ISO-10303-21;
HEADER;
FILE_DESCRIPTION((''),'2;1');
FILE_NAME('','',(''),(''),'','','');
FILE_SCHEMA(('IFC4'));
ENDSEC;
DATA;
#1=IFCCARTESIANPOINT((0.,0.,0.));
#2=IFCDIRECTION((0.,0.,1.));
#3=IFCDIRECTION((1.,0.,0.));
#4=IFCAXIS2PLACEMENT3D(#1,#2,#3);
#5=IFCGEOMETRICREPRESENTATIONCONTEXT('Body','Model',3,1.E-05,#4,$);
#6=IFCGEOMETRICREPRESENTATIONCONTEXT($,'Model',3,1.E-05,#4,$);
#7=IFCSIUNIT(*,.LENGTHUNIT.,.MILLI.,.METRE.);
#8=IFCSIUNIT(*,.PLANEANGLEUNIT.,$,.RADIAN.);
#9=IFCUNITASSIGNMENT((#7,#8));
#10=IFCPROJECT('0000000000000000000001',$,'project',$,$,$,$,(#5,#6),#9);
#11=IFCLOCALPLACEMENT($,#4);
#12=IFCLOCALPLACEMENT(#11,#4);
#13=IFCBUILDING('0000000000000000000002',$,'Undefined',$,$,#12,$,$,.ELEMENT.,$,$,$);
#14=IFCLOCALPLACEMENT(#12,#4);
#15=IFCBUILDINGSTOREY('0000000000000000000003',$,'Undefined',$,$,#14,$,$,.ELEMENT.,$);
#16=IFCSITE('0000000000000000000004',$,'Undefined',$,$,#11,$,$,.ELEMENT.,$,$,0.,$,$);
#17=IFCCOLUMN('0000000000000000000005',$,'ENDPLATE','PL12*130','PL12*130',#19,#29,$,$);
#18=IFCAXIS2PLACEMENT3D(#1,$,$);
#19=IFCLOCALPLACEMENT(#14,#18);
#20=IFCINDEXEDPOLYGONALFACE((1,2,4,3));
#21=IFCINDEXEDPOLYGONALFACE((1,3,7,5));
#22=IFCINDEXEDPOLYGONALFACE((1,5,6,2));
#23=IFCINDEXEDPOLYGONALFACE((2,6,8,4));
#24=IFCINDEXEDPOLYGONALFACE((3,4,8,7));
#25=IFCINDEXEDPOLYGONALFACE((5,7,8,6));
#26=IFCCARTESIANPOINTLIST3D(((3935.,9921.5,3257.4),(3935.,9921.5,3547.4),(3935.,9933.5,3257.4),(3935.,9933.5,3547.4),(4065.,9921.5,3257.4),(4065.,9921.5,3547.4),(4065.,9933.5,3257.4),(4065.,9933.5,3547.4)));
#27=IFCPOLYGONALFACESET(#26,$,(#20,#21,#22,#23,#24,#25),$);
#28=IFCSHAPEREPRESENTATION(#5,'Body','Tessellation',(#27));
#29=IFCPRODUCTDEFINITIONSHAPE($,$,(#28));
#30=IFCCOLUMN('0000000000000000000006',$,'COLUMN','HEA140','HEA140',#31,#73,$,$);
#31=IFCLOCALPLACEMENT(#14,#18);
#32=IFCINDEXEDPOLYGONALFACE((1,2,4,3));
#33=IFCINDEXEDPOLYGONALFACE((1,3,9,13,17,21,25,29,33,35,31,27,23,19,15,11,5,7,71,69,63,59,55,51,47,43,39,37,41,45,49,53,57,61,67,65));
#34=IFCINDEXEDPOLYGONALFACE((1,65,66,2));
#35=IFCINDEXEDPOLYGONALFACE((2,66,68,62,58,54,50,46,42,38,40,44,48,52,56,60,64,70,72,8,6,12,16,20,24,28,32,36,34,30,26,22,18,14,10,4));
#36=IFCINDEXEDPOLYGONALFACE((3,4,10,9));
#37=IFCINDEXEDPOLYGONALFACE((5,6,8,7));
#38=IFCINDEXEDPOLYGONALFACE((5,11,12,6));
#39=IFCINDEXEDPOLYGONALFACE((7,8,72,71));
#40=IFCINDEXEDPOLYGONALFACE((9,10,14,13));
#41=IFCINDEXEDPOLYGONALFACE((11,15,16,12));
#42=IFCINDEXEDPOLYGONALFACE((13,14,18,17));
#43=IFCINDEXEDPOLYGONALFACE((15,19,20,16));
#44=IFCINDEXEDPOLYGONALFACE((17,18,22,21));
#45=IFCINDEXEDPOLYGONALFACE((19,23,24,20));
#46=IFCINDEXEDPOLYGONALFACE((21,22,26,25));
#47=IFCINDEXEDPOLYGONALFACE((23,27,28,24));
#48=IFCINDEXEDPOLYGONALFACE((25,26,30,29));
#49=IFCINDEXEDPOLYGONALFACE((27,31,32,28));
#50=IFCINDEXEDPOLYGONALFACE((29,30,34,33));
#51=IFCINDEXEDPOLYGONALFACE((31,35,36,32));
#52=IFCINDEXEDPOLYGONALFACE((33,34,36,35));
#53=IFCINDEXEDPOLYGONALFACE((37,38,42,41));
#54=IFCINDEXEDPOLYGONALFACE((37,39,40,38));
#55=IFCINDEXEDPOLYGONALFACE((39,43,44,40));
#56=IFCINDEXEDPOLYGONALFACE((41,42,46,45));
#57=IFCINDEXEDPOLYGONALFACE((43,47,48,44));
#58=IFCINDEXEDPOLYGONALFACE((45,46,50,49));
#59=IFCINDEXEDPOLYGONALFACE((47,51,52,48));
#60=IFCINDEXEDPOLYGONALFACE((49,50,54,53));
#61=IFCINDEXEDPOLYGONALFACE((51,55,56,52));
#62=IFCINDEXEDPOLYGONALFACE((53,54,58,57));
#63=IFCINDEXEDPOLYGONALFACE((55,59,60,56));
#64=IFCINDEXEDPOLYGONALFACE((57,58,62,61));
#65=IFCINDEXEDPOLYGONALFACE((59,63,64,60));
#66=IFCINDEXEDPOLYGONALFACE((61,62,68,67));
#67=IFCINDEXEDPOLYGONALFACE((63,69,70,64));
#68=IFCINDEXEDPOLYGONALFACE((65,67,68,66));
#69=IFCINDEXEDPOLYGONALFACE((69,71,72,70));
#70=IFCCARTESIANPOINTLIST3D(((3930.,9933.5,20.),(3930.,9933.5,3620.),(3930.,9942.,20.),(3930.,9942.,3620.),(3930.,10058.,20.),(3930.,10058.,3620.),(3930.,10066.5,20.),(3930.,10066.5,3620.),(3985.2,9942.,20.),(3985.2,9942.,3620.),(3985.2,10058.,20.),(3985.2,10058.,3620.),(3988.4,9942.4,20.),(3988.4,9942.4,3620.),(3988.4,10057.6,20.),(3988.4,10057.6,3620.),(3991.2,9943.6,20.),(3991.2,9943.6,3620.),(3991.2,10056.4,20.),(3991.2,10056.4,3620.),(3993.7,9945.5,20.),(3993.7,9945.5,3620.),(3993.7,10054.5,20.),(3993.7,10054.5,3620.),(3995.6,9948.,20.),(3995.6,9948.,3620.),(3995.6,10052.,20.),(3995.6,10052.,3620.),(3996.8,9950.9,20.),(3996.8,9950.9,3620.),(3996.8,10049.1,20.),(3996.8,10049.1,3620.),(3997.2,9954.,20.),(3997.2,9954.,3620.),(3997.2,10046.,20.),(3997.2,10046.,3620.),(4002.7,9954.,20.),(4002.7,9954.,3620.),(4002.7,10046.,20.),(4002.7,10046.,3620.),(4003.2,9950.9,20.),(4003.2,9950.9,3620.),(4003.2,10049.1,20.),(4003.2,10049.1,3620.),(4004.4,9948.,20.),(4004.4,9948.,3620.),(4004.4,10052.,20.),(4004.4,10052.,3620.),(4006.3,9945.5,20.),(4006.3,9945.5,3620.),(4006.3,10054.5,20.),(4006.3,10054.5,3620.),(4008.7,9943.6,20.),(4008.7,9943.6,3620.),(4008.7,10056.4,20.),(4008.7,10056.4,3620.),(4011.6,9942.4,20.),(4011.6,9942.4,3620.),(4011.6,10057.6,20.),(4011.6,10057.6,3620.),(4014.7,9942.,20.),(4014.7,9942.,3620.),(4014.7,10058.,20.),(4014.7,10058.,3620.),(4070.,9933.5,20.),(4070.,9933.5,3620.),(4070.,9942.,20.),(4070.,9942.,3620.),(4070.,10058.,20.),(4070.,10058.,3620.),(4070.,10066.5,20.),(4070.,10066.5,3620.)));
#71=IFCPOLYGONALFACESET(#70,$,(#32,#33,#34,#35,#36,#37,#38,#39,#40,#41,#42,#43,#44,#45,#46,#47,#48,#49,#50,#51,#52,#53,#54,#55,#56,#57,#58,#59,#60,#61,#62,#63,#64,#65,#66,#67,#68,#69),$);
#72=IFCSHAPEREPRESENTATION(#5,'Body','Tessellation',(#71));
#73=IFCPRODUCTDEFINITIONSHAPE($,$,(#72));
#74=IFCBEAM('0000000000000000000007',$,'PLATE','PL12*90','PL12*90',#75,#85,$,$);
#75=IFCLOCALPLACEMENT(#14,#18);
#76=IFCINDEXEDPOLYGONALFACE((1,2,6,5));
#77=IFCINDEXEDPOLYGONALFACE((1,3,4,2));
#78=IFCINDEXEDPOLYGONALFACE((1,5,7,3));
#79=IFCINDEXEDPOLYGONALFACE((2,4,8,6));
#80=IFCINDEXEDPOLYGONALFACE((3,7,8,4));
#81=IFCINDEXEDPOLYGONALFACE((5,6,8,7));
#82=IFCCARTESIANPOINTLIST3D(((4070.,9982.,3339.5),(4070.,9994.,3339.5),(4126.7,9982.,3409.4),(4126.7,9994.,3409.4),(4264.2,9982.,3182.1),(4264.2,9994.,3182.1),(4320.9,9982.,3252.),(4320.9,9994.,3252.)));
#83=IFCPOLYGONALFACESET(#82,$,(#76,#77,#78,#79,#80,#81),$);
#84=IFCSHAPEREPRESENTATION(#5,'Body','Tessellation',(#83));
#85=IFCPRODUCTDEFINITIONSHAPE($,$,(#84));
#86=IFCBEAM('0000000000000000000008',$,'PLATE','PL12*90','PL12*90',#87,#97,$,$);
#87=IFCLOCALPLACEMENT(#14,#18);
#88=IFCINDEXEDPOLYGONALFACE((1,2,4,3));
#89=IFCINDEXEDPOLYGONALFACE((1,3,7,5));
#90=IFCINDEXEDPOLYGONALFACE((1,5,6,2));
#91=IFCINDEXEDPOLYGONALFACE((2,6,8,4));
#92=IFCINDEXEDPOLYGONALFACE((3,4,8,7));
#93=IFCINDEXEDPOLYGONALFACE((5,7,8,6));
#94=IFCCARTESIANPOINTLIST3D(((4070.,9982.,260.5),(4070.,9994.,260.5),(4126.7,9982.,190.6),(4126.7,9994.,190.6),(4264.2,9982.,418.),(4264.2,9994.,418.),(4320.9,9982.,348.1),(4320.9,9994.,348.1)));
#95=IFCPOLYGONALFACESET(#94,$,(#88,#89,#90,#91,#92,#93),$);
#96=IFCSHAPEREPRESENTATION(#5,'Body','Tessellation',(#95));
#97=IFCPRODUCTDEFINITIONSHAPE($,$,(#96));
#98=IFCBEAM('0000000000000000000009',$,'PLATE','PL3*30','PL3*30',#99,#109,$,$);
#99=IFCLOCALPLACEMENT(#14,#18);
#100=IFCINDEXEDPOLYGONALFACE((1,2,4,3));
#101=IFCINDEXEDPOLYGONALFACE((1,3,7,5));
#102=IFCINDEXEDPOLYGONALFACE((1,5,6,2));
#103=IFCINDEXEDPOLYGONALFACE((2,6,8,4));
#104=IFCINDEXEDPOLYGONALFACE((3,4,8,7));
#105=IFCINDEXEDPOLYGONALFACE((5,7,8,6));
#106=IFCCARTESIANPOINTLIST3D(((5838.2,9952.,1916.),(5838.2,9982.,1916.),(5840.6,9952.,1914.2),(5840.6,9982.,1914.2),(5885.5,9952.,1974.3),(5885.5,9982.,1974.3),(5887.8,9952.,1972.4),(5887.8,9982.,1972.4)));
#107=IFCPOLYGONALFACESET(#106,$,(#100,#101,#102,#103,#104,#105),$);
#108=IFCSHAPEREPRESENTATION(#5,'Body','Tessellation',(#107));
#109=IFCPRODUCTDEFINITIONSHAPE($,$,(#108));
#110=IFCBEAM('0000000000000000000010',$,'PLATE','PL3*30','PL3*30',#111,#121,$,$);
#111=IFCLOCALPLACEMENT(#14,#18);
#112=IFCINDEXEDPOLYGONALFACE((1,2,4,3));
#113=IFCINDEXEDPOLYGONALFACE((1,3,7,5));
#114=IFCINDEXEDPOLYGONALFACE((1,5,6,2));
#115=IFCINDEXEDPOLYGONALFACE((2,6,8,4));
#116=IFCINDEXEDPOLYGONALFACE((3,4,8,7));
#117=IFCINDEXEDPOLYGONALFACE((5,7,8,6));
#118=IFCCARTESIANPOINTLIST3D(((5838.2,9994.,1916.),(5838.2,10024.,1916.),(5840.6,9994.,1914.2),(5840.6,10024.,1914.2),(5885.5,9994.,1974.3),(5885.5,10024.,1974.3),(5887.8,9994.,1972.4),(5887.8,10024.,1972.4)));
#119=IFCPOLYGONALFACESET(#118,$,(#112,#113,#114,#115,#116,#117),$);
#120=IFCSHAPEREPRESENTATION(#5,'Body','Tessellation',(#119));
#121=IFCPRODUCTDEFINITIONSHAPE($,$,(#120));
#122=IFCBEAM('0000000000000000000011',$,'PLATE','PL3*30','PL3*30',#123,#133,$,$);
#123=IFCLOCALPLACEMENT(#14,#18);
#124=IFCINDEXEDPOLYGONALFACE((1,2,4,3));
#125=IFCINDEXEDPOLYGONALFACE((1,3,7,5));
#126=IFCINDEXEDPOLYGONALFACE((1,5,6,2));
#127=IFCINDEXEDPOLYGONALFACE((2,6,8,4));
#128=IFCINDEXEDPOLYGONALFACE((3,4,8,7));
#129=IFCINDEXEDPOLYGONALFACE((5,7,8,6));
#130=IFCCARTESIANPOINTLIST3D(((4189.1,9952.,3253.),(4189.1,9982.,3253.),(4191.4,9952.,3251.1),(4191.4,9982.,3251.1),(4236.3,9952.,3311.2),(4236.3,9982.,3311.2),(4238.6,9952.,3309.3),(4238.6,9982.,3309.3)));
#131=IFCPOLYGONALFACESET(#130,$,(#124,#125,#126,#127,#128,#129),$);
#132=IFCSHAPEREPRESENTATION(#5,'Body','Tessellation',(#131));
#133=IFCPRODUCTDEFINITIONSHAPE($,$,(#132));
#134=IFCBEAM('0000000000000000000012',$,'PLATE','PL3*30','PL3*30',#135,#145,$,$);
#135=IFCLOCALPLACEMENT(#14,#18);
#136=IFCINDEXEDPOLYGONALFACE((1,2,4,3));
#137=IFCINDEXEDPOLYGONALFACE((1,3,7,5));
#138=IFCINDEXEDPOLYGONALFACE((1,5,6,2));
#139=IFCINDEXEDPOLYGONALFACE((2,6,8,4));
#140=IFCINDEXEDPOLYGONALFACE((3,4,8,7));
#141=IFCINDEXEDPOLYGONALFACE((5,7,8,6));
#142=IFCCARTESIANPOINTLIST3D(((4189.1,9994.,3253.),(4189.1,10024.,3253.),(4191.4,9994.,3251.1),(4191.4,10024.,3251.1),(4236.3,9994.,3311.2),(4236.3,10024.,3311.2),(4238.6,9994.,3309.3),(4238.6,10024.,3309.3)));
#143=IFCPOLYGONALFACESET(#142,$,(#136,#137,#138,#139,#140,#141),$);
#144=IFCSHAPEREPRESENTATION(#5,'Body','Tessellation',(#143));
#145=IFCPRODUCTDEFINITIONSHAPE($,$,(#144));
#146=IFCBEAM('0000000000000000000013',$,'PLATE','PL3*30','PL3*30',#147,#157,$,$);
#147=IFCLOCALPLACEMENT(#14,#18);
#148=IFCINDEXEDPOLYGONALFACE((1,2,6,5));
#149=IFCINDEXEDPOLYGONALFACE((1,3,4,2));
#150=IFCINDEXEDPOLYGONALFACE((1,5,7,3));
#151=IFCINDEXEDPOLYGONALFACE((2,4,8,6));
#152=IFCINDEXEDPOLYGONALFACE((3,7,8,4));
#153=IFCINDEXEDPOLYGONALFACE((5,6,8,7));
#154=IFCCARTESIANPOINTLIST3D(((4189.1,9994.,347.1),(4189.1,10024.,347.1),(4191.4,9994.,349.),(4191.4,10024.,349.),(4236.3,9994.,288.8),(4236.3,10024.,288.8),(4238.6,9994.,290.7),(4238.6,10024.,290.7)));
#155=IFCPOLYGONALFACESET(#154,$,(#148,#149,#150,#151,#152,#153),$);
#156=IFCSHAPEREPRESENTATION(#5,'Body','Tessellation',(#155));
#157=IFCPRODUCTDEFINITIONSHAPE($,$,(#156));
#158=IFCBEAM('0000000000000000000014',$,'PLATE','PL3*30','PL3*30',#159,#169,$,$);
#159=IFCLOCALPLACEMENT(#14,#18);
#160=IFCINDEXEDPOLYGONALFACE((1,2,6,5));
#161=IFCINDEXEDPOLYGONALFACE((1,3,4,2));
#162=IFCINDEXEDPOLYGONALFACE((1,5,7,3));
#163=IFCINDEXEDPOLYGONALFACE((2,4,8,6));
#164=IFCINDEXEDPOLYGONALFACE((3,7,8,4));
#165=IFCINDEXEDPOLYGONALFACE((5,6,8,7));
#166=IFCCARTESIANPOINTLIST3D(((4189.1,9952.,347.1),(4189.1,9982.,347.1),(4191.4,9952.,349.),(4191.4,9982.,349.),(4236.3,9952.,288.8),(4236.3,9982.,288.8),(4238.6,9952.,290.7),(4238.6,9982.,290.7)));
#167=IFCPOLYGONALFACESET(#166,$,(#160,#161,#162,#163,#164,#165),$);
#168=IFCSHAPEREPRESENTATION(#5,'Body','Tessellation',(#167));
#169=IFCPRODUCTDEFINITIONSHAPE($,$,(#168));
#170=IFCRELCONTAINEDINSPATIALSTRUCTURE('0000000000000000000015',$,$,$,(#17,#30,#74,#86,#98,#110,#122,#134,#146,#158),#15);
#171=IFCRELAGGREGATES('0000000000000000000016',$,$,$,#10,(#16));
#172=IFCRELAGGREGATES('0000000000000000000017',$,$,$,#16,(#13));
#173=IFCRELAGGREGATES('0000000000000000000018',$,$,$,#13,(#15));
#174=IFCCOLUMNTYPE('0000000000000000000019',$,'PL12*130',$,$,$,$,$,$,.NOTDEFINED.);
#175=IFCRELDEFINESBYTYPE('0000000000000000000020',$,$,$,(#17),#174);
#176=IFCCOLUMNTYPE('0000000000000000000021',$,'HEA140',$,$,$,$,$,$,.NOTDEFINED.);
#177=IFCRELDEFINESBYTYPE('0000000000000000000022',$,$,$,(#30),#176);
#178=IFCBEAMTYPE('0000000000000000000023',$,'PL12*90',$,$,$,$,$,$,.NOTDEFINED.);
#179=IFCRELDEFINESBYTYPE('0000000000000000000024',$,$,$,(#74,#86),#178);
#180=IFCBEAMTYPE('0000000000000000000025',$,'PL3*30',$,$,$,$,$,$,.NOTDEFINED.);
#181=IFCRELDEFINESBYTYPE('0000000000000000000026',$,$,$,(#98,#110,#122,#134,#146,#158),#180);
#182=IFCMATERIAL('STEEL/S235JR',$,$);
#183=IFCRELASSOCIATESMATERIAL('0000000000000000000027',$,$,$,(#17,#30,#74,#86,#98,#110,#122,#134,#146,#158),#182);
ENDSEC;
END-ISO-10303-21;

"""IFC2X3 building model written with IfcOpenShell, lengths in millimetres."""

from ifc_helpers import new_model, si_unit, frame, origin_with_axes, origin_2d_with_axis, place, context, project, spatial, rectangle, i_section, extrude, material, type_object, element, save


model = new_model("IFC2X3")

# Units and contexts
model_context_1 = context("Model", 3, precision=1e-05, world=origin_with_axes(), identifier="Body")
model_context_2 = context("Model", 3, precision=1e-05, world=origin_with_axes())
ifc_project = project(units=[si_unit("LENGTHUNIT", "METRE", prefix="MILLI"), si_unit("PLANEANGLEUNIT", "RADIAN")], contexts=[model_context_1, model_context_2])

# Site, building, storey
site_placement = place(None, origin_with_axes())
site = spatial("IfcSite", under=ifc_project, at=site_placement, Name="Undefined", CompositionType="ELEMENT", RefElevation=0.0)
building_placement = place(site_placement, origin_with_axes())
building = spatial("IfcBuilding", under=site, at=building_placement, Name="Undefined", CompositionType="ELEMENT")
storey_placement = place(building_placement, origin_with_axes())
storey = spatial("IfcBuildingStorey", under=building, at=storey_placement, Name="Undefined", CompositionType="ELEMENT")

# Columns
ifc_material = material(Name="STEEL/S235JR")
column_type_1 = type_object("IfcColumnType", Name="PL12*130", PredefinedType="NOTDEFINED")
column_1_placement = place(storey_placement, frame((4000.0, 9927.5, 3257.4), z_axis=(0.0, 0.0, 1.0), x_axis=(1.0, 0.0, 0.0)))
element("IfcColumn", 1, at=column_1_placement, inside=storey, type_object=column_type_1, material=ifc_material, Name="ENDPLATE", Description="PL12*130", ObjectType="PL12*130", context=model_context_1, shape_type="SweptSolid", body=[
    extrude(rectangle(XDim=12.0, YDim=130.0, at=origin_2d_with_axis()), frame((0.0, 0.0, 290.0), z_axis=(0.0, 0.0, -1.0), x_axis=(0.0, -1.0, 0.0)), (0.0, 0.0, 1.0), 290.0),
])
column_type_2 = type_object("IfcColumnType", Name="HEA140", PredefinedType="NOTDEFINED")
column_2_placement = place(storey_placement, frame((4000.0, 10000.0, -180.0), z_axis=(0.0, 0.0, 1.0), x_axis=(1.0, 0.0, 0.0)))
element("IfcColumn", 2, at=column_2_placement, inside=storey, type_object=column_type_2, material=ifc_material, Name="COLUMN", Description="HEA140", ObjectType="HEA140", context=model_context_1, shape_type="SweptSolid", body=[
    extrude(i_section(OverallWidth=140.0, OverallDepth=133.0, WebThickness=5.5, FlangeThickness=8.5, FilletRadius=12.0, at=origin_2d_with_axis()), frame((0.0, 0.0, 3800.0), z_axis=(0.0, 0.0, -1.0), x_axis=(-1.0, 0.0, 0.0)), (0.0, 0.0, 1.0), 3600.0),
])

# Beams
beam_type_1 = type_object("IfcBeamType", Name="PL12*90", PredefinedType="NOTDEFINED")
beam_1_placement = place(storey_placement, frame((4098.3, 9988.0, 3374.5), z_axis=(0.629738, 0.0, 0.776808), x_axis=(0.776808, 0.0, -0.629738)))
element("IfcBeam", 3, at=beam_1_placement, inside=storey, type_object=beam_type_1, material=ifc_material, Name="PLATE", Description="PL12*90", ObjectType="PL12*90", context=model_context_1, shape_type="SweptSolid", body=[
    extrude(rectangle(XDim=12.0, YDim=90.0, at=origin_2d_with_axis()), frame((250.0, 0.0, 0.0), z_axis=(-1.0, 0.0, 0.0), x_axis=(0.0, -1.0, 0.0)), (0.0, 0.0, 1.0), 250.0),
])
beam_2_placement = place(storey_placement, frame((4098.3, 9988.0, 225.5), z_axis=(0.629835, 0.0, -0.776729), x_axis=(0.776729, 0.0, 0.629835)))
element("IfcBeam", 4, at=beam_2_placement, inside=storey, type_object=beam_type_1, material=ifc_material, Name="PLATE", Description="PL12*90", ObjectType="PL12*90", context=model_context_1, shape_type="SweptSolid", body=[
    extrude(rectangle(XDim=12.0, YDim=90.0, at=origin_2d_with_axis()), frame((250.0, 0.0, 0.0), z_axis=(-1.0, 0.0, 0.0), x_axis=(0.0, -1.0, 0.0)), (0.0, 0.0, 1.0), 250.0),
])
beam_type_2 = type_object("IfcBeamType", Name="PL3*30", PredefinedType="NOTDEFINED")
for number, where, z_axis, x_axis, name in (
    (5, (5839.4, 9967.0, 1915.1), (0.0, 1.0, 0.0), (0.629738, 0.0, 0.776808), "PLATE"),
    (6, (5839.4, 10009.0, 1915.1), (0.0, -1.0, 0.0), (0.629738, 0.0, 0.776808), "PLATE"),
):
    element("IfcBeam", number, at=place(storey_placement, frame(where, z_axis=z_axis, x_axis=x_axis)), inside=storey, type_object=beam_type_2, material=ifc_material, Name=name, Description="PL3*30", ObjectType="PL3*30", context=model_context_1, shape_type="SweptSolid", body=[
        extrude(rectangle(XDim=3.0, YDim=30.0, at=origin_2d_with_axis()), frame((75.0, 0.0, 0.0), z_axis=(-1.0, 0.0, 0.0), x_axis=(0.0, -1.0, 0.0)), (0.0, 0.0, 1.0), 75.0),
    ])
for number, where, z_axis, x_axis, name in (
    (7, (4190.2, 9967.0, 3252.0), (0.0, 1.0, 0.0), (0.629738, 0.0, 0.776808), "PLATE"),
    (8, (4190.2, 10009.0, 3252.0), (0.0, -1.0, 0.0), (0.629738, 0.0, 0.776808), "PLATE"),
):
    element("IfcBeam", number, at=place(storey_placement, frame(where, z_axis=z_axis, x_axis=x_axis)), inside=storey, type_object=beam_type_2, material=ifc_material, Name=name, Description="PL3*30", ObjectType="PL3*30", context=model_context_1, shape_type="SweptSolid", body=[
        extrude(rectangle(XDim=3.0, YDim=30.0, at=origin_2d_with_axis()), frame((75.0, 0.0, 0.0), z_axis=(-1.0, 0.0, 0.0), x_axis=(0.0, -1.0, 0.0)), (0.0, 0.0, 1.0), 75.0),
    ])
for number, where, z_axis, x_axis, name in (
    (9, (4190.2, 10009.0, 348.0), (0.0, -1.0, 0.0), (0.629835, 0.0, -0.776729), "PLATE"),
    (10, (4190.2, 9967.0, 348.0), (0.0, 1.0, 0.0), (0.629835, 0.0, -0.776729), "PLATE"),
):
    element("IfcBeam", number, at=place(storey_placement, frame(where, z_axis=z_axis, x_axis=x_axis)), inside=storey, type_object=beam_type_2, material=ifc_material, Name=name, Description="PL3*30", ObjectType="PL3*30", context=model_context_1, shape_type="SweptSolid", body=[
        extrude(rectangle(XDim=3.0, YDim=30.0, at=origin_2d_with_axis()), frame((75.0, 0.0, 0.0), z_axis=(-1.0, 0.0, 0.0), x_axis=(0.0, -1.0, 0.0)), (0.0, 0.0, 1.0), 75.0),
    ])

save(model, "model.ifc")
